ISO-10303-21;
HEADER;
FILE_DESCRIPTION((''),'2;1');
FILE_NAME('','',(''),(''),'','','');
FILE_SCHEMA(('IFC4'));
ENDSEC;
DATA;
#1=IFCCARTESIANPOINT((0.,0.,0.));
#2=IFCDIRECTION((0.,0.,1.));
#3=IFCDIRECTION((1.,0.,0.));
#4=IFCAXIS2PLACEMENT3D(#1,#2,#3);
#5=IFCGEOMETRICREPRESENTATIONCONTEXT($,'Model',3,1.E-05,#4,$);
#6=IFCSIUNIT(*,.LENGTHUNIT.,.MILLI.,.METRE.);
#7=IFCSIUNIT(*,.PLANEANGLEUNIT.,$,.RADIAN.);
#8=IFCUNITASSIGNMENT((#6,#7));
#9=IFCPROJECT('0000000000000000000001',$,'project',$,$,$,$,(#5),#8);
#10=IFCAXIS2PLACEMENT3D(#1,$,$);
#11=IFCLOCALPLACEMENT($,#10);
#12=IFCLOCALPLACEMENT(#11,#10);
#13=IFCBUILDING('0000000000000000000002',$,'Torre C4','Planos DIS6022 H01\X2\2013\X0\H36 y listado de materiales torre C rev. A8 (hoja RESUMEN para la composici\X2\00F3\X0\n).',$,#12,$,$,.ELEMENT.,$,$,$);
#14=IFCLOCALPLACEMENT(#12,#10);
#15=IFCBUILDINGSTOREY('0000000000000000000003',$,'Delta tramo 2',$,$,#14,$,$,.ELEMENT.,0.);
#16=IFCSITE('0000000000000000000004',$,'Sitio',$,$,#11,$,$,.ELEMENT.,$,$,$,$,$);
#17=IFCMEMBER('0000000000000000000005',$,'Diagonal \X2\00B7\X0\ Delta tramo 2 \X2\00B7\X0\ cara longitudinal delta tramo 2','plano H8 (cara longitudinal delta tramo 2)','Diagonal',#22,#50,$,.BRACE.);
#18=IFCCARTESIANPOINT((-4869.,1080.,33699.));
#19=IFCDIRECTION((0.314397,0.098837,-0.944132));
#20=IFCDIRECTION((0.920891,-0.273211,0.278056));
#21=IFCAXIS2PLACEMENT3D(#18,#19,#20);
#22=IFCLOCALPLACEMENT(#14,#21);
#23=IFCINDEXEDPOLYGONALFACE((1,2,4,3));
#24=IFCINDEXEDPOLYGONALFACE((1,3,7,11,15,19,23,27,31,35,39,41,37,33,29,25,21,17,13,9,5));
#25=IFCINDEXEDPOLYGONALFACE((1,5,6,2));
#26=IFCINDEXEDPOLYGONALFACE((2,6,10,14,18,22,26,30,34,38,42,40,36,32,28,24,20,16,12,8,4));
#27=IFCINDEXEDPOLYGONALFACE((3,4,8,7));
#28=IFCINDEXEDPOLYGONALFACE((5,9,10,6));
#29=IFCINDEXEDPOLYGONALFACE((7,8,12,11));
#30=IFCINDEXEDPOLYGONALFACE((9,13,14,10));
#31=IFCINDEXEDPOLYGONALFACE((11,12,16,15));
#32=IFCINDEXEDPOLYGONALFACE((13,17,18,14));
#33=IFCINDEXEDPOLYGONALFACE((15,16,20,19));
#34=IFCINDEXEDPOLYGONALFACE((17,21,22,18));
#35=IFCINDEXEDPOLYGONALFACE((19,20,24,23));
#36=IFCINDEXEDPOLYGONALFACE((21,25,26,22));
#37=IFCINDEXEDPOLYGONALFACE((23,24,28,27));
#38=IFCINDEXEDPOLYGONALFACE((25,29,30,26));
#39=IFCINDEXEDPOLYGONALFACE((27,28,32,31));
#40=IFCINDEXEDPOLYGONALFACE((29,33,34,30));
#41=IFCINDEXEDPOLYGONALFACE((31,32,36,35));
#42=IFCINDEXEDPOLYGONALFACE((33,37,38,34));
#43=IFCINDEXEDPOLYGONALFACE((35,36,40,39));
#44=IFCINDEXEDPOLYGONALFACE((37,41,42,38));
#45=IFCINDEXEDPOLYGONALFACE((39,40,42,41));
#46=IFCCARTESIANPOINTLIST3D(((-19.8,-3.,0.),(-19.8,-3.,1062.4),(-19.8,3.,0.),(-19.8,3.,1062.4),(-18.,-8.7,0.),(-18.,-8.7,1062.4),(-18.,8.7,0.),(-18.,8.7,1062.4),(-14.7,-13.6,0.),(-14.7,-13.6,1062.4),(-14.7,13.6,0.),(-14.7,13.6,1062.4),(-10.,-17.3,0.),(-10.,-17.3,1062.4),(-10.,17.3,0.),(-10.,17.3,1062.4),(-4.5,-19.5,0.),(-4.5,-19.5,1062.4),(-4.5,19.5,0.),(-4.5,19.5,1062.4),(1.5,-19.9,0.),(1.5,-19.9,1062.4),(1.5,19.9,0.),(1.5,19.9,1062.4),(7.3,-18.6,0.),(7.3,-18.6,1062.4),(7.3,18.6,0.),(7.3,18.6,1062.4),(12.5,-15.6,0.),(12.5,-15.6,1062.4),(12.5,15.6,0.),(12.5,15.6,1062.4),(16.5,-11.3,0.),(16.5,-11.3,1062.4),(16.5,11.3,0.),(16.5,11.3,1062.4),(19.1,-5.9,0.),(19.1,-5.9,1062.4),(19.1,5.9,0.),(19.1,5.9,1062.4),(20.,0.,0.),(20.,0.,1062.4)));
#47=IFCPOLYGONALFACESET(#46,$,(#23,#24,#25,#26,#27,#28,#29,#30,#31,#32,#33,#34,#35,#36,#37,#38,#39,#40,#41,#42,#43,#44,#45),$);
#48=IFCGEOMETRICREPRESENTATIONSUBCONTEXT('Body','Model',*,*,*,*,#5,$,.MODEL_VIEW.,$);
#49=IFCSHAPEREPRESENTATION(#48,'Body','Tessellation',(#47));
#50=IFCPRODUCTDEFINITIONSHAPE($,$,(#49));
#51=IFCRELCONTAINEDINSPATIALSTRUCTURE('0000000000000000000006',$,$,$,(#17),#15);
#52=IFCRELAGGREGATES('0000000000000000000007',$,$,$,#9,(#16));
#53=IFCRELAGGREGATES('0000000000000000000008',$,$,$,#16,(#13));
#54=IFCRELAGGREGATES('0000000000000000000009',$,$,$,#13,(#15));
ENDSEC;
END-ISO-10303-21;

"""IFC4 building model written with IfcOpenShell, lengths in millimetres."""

from ifc_helpers import new_model, si_unit, frame, origin, origin_with_axes, place, context, subcontext, project, spatial, circle, extrude, element, save


model = new_model("IFC4")

# Units and contexts
model_context = context("Model", 3, precision=1e-05, world=origin_with_axes())
body_context = subcontext(model_context, "Body", "Model", "MODEL_VIEW")
ifc_project = project(units=[si_unit("LENGTHUNIT", "METRE", prefix="MILLI"), si_unit("PLANEANGLEUNIT", "RADIAN")], contexts=[model_context])

# Site, building, storey
site_placement = place(None, origin())
site = spatial("IfcSite", under=ifc_project, at=site_placement, Name="Sitio", CompositionType="ELEMENT")
building_placement = place(site_placement, origin())
building = spatial("IfcBuilding", under=site, at=building_placement, Name="Torre C4", Description="Planos DIS6022 H01–H36 y listado de materiales torre C rev. A8 (hoja RESUMEN para la composición).", CompositionType="ELEMENT")
storey_placement = place(building_placement, origin())
storey = spatial("IfcBuildingStorey", under=building, at=storey_placement, Name="Delta tramo 2", CompositionType="ELEMENT", Elevation=0.0)

# Member
member_1_placement = place(storey_placement, frame((-4869.0, 1080.0, 33699.0), z_axis=(0.314397, 0.098837, -0.944132), x_axis=(0.920891, -0.273211, 0.278056)))
element("IfcMember", 1, at=member_1_placement, inside=storey, Name="Diagonal · Delta tramo 2 · cara longitudinal delta tramo 2", Description="plano H8 (cara longitudinal delta tramo 2)", ObjectType="Diagonal", PredefinedType="BRACE", context=body_context, shape_type="SweptSolid", body=[
    extrude(circle(Radius=20.0), None, (0.0, 0.0, 1.0), 1062.4),
])

save(model, "model.ifc")
